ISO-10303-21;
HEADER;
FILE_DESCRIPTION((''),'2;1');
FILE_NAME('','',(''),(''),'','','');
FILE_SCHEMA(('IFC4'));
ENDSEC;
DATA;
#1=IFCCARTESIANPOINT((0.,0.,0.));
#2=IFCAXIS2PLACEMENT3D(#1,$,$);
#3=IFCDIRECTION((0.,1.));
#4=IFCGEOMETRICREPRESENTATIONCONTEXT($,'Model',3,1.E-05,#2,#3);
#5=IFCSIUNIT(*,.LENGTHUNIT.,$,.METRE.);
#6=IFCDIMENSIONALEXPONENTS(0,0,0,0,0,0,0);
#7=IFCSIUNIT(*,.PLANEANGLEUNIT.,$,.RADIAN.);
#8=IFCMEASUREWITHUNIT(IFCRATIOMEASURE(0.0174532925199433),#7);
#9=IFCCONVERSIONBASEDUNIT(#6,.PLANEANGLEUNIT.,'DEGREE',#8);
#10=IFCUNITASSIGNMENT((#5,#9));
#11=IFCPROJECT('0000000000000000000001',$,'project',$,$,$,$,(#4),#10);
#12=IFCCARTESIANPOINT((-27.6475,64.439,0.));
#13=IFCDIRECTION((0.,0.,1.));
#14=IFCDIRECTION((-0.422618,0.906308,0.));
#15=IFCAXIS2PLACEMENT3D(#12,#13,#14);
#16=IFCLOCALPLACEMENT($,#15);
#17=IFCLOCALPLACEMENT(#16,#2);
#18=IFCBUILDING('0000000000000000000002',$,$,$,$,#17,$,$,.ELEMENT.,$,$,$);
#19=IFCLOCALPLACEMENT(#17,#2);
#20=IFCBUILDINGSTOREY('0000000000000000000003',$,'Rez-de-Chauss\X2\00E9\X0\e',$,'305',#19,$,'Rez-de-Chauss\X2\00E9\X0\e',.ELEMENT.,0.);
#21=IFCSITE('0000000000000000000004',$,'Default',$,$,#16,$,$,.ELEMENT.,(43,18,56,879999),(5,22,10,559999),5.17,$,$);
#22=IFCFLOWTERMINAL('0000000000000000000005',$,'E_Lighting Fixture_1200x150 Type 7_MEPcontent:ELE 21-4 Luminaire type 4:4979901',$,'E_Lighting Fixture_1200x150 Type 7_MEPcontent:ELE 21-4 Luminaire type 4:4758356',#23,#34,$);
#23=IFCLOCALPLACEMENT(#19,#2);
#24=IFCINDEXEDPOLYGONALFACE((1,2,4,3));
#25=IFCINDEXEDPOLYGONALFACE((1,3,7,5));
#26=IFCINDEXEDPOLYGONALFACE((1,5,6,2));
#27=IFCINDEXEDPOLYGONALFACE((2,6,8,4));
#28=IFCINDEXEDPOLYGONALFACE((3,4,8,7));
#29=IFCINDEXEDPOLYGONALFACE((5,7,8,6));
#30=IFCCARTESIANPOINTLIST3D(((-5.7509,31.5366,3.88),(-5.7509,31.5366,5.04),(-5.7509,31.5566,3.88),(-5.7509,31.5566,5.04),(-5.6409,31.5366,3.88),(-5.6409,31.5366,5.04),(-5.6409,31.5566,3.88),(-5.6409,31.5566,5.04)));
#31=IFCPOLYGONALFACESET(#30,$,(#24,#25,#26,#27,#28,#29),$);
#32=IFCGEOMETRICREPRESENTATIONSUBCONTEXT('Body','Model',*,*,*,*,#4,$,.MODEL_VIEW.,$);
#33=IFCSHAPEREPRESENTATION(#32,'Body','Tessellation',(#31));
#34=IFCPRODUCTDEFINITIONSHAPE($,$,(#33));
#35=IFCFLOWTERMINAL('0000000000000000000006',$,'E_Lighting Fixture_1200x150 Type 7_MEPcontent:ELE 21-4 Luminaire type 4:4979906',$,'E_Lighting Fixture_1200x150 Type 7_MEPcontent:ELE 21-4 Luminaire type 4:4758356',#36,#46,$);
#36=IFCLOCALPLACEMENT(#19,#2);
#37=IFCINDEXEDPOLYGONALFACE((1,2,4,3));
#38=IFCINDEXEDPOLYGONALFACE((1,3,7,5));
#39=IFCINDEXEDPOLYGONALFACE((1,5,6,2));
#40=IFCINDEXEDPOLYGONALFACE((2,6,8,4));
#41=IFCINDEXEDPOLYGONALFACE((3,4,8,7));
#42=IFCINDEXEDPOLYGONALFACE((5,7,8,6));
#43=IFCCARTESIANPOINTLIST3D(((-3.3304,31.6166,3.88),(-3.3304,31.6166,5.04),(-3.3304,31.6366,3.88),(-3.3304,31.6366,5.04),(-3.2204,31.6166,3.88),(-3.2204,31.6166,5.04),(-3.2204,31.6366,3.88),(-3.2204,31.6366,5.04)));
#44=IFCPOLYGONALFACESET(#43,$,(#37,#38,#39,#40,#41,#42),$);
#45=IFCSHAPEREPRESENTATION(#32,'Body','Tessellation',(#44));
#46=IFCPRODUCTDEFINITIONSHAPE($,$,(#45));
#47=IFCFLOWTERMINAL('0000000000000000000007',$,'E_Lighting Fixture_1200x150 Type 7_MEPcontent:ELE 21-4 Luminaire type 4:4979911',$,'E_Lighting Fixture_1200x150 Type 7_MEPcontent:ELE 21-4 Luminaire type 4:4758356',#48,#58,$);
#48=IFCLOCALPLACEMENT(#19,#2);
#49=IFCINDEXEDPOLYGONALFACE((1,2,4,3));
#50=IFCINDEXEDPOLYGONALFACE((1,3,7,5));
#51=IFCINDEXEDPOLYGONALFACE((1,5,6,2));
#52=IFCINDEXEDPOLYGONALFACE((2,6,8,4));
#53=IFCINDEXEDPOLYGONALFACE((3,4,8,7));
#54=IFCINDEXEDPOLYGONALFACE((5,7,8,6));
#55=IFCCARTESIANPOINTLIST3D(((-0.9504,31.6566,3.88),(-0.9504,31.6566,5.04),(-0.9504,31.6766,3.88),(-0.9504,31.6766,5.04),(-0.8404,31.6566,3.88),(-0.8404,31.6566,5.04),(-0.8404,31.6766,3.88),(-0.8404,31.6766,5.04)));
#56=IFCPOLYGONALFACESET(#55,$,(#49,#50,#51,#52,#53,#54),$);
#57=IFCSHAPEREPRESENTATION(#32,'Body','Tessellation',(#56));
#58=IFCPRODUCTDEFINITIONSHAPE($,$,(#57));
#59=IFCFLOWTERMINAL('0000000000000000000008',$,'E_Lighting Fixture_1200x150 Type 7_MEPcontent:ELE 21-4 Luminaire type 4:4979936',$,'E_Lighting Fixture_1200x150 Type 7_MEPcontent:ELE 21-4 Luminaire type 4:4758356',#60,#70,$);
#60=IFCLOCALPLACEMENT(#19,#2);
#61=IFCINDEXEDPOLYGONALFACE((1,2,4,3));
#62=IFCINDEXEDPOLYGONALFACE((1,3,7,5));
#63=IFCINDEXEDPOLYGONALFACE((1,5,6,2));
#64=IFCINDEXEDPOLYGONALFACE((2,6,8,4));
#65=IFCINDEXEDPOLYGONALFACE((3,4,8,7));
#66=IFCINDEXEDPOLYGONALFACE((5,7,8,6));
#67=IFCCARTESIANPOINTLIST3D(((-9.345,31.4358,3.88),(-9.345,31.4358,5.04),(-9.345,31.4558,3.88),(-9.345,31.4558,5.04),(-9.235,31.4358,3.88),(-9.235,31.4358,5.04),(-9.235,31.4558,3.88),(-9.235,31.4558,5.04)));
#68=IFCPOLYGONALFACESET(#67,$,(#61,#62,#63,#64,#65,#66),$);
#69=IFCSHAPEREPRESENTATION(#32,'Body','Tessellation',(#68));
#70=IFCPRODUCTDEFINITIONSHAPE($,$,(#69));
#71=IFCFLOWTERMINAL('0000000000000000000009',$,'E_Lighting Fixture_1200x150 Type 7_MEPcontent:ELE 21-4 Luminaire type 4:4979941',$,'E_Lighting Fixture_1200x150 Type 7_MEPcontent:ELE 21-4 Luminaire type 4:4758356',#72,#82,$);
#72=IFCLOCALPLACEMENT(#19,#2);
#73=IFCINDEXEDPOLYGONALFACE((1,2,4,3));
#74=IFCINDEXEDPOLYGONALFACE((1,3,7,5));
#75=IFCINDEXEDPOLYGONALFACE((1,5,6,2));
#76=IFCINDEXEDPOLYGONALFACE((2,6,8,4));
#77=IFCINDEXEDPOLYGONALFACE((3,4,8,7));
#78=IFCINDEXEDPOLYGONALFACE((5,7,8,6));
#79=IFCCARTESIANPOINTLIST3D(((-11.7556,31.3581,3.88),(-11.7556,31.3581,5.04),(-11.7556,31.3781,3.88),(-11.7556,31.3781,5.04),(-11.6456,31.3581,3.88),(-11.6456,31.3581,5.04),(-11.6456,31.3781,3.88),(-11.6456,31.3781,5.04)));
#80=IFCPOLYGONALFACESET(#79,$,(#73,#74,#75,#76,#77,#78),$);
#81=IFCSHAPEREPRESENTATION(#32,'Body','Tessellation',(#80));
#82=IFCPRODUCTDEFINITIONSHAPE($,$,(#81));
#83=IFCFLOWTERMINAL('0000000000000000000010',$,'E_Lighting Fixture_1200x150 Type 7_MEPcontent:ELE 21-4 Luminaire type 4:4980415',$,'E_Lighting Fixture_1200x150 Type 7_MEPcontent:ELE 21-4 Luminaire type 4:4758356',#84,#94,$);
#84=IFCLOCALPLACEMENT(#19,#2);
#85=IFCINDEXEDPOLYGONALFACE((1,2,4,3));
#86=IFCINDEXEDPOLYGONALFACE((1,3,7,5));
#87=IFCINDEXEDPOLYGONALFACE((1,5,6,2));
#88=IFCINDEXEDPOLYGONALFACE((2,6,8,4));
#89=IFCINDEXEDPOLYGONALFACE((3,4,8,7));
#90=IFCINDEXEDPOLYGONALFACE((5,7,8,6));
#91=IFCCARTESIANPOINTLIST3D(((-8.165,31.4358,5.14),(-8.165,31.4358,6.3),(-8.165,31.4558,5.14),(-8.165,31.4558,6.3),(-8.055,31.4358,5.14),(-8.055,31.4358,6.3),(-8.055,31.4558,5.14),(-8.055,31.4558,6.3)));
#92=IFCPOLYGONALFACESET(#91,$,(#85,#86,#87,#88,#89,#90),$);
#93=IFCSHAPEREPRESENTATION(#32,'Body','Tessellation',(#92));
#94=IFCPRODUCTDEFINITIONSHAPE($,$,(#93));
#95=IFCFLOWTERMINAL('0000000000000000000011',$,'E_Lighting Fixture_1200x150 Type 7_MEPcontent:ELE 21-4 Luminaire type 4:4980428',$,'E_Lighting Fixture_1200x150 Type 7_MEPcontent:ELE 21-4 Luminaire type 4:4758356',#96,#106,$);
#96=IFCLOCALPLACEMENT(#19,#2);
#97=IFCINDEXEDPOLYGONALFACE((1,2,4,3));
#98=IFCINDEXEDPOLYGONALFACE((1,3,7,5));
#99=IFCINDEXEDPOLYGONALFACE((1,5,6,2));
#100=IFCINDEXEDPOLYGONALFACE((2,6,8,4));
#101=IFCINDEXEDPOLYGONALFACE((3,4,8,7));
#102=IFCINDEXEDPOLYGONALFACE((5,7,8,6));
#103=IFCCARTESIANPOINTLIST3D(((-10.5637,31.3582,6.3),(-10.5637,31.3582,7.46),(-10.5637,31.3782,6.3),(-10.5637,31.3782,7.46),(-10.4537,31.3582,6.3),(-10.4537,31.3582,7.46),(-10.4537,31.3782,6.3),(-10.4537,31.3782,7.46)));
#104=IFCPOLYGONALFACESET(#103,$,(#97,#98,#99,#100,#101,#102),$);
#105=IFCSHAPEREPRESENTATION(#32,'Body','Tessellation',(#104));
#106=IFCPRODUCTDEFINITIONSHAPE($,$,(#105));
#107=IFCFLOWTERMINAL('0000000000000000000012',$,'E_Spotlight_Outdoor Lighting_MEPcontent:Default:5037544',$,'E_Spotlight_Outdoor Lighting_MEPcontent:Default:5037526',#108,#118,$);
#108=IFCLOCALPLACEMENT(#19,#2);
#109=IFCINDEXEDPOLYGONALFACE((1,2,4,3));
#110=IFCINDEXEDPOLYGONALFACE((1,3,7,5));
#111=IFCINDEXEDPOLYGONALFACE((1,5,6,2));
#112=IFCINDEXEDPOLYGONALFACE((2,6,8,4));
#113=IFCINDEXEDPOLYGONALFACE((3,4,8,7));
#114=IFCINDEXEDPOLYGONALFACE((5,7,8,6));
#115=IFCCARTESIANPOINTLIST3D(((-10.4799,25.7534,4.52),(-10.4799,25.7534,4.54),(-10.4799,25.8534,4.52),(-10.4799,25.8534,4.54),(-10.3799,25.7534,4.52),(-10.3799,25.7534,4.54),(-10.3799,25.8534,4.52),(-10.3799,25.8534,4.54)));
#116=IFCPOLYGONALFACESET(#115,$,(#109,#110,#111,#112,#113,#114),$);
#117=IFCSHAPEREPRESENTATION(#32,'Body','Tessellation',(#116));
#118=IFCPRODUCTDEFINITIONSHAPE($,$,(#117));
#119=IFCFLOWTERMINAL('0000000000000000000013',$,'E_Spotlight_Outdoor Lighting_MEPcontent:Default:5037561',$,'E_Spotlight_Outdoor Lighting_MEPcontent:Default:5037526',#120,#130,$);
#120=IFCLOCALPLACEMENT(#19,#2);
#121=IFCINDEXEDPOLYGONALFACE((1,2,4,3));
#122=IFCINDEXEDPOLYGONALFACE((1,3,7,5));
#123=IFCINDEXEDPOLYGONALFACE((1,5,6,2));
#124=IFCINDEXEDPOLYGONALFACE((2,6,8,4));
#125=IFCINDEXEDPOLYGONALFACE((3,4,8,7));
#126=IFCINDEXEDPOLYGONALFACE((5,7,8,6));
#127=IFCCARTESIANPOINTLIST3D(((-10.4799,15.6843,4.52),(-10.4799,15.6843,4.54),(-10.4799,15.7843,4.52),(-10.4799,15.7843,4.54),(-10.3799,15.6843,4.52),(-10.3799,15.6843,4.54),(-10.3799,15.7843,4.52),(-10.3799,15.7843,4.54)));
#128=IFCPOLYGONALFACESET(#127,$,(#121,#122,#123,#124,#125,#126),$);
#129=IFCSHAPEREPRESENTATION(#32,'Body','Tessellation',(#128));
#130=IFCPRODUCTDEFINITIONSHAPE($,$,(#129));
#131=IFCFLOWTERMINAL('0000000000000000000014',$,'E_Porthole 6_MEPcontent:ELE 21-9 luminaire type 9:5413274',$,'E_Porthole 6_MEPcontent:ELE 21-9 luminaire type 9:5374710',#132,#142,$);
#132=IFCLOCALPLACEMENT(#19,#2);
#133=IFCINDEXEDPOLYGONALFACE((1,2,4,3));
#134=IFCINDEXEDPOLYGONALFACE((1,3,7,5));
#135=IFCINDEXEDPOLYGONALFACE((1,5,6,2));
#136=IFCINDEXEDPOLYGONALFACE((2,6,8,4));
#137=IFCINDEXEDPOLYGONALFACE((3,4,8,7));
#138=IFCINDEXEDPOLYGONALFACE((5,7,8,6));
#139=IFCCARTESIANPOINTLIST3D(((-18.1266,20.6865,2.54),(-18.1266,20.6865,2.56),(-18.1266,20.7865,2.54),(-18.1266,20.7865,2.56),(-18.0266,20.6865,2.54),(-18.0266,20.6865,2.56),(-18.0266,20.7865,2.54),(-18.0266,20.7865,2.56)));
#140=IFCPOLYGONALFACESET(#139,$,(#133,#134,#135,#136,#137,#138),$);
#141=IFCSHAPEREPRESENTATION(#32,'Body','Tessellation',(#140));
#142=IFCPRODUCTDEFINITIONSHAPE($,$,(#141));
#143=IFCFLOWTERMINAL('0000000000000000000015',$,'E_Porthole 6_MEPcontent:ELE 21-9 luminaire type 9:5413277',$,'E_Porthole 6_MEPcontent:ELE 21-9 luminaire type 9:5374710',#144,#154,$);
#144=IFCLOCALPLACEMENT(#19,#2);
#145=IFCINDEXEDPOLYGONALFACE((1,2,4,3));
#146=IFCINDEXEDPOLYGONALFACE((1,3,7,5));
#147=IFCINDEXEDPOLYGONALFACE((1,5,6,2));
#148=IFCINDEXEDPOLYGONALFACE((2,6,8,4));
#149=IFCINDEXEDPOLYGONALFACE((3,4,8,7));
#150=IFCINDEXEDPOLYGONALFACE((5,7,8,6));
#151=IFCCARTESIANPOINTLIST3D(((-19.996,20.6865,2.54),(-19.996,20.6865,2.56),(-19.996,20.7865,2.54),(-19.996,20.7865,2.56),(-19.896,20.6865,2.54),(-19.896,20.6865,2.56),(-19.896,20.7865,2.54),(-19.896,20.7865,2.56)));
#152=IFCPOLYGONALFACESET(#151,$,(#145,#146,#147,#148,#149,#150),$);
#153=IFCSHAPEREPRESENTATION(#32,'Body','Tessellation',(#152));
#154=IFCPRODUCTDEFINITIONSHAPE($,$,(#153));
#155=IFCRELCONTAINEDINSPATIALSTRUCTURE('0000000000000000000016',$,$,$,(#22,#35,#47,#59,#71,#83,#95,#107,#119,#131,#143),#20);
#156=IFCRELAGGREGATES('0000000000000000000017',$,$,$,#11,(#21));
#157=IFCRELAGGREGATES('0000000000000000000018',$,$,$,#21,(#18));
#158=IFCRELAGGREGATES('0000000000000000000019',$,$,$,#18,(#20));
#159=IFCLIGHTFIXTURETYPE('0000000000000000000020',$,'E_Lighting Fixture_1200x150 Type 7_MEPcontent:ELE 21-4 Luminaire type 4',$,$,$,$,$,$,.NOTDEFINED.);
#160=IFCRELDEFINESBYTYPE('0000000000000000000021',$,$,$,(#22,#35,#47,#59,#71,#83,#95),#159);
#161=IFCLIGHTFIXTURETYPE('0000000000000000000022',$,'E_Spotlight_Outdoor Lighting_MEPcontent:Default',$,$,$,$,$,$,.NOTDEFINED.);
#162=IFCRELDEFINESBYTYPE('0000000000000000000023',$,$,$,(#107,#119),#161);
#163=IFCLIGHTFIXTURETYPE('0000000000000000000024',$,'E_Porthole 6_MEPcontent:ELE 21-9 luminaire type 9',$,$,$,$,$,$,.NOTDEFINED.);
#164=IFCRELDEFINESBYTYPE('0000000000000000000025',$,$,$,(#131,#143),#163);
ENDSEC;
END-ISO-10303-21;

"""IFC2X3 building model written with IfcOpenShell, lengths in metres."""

from ifc_helpers import new_model, entity, si_unit, converted_unit, direction, frame, frame_2d, origin, origin_2d_with_axis, place, context, subcontext, project, spatial, rectangle, extrude, source, transform, mapped, type_object, type_shapes, element, save


model = new_model("IFC2X3")

# Units and contexts
model_context = context("Model", 3, precision=1e-05, world=origin(), true_north=direction((0.0, 1.0)))
body_context = subcontext(model_context, "Body", "Model", "MODEL_VIEW")
ifc_project = project(units=[si_unit("LENGTHUNIT", "METRE"), converted_unit("PLANEANGLEUNIT", "DEGREE", entity("IfcRatioMeasure", 0.0174532925199433), si_unit("PLANEANGLEUNIT", "RADIAN"), dimensions=[0, 0, 0, 0, 0, 0, 0])], contexts=[model_context])

# Site, building, storey
site_placement = place(None, frame((-27.6475, 64.439, 0.0), z_axis=(0.0, 0.0, 1.0), x_axis=(-0.422618, 0.906308, 0.0)))
site = spatial("IfcSite", under=ifc_project, at=site_placement, Name="Default", CompositionType="ELEMENT", RefLatitude=(43, 18, 56, 879999), RefLongitude=(5, 22, 10, 559999), RefElevation=5.17)
building_placement = place(site_placement, origin())
building = spatial("IfcBuilding", under=site, at=building_placement, CompositionType="ELEMENT")
storey_placement = place(building_placement, origin())
storey = spatial("IfcBuildingStorey", under=building, at=storey_placement, Name="Rez-de-Chaussée", ObjectType="305", LongName="Rez-de-Chaussée", CompositionType="ELEMENT", Elevation=0.0)

# Flow terminals
light_fixture_type_1 = type_object("IfcLightFixtureType", Name="E_Lighting Fixture_1200x150 Type 7_MEPcontent:ELE 21-4 Luminaire type 4", PredefinedType="NOTDEFINED")
shared_shape_1 = source(origin(), body_context, "Body", "SweptSolid", [
    extrude(rectangle(XDim=0.02, YDim=0.11, at=frame_2d((0.0, 0.0), x_axis=(1.0, 0.0))), frame((0.01, 0.0, -0.58), z_axis=(0.0, 0.0, 1.0), x_axis=(-1.0, 0.0, 0.0)), (0.0, 0.0, 1.0), 1.16),
])
type_shapes(light_fixture_type_1, [shared_shape_1])
for number, where, z_axis, x_axis, name in (
    (1, (-5.6959, 31.5566, 4.46), (0.0, 0.0, 1.0), (0.0, -1.0, 0.0), "E_Lighting Fixture_1200x150 Type 7_MEPcontent:ELE 21-4 Luminaire type 4:4979901"),
    (2, (-3.2754, 31.6366, 4.46), (0.0, 0.0, 1.0), (0.0, -1.0, 0.0), "E_Lighting Fixture_1200x150 Type 7_MEPcontent:ELE 21-4 Luminaire type 4:4979906"),
    (3, (-0.8954, 31.6766, 4.46), (0.0, 0.0, 1.0), (0.0, -1.0, 0.0), "E_Lighting Fixture_1200x150 Type 7_MEPcontent:ELE 21-4 Luminaire type 4:4979911"),
    (4, (-9.29, 31.4558, 4.46), (0.0, 0.0, 1.0), (0.0, -1.0, 0.0), "E_Lighting Fixture_1200x150 Type 7_MEPcontent:ELE 21-4 Luminaire type 4:4979936"),
    (5, (-11.7006, 31.3781, 4.46), (0.0, 0.0, 1.0), (0.0, -1.0, 0.0), "E_Lighting Fixture_1200x150 Type 7_MEPcontent:ELE 21-4 Luminaire type 4:4979941"),
    (6, (-8.11, 31.4558, 5.72), (0.0, 0.0, 1.0), (0.0, -1.0, 0.0), "E_Lighting Fixture_1200x150 Type 7_MEPcontent:ELE 21-4 Luminaire type 4:4980415"),
    (7, (-10.5087, 31.3782, 6.88), (0.0, 0.0, 1.0), (0.0, -1.0, 0.0), "E_Lighting Fixture_1200x150 Type 7_MEPcontent:ELE 21-4 Luminaire type 4:4980428"),
):
    element("IfcFlowTerminal", number, at=place(storey_placement, frame(where, z_axis=z_axis, x_axis=x_axis)), inside=storey, type_object=light_fixture_type_1, Name=name, ObjectType="E_Lighting Fixture_1200x150 Type 7_MEPcontent:ELE 21-4 Luminaire type 4:4758356", context=body_context, shape_type="MappedRepresentation", body=[
        mapped(shared_shape_1, transform((0.0, 0.0, 0.0), scale=1.0)),
    ])
light_fixture_type_2 = type_object("IfcLightFixtureType", Name="E_Spotlight_Outdoor Lighting_MEPcontent:Default", PredefinedType="NOTDEFINED")
shared_shape_2 = source(origin(), body_context, "Body", "SweptSolid", [
    extrude(rectangle(XDim=0.1, YDim=0.1, at=origin_2d_with_axis()), frame((0.0, 0.0, 0.0), z_axis=(0.0, 0.0, 1.0), x_axis=(0.0, -1.0, 0.0)), (0.0, 0.0, 1.0), 0.02),
])
type_shapes(light_fixture_type_2, [shared_shape_2])
for number, where, z_axis, x_axis, name in (
    (8, (-10.4299, 25.8034, 4.52), (0.0, 0.0, 1.0), (0.0, -1.0, 0.0), "E_Spotlight_Outdoor Lighting_MEPcontent:Default:5037544"),
    (9, (-10.4299, 15.7343, 4.52), (0.0, 0.0, 1.0), (0.0, -1.0, 0.0), "E_Spotlight_Outdoor Lighting_MEPcontent:Default:5037561"),
):
    element("IfcFlowTerminal", number, at=place(storey_placement, frame(where, z_axis=z_axis, x_axis=x_axis)), inside=storey, type_object=light_fixture_type_2, Name=name, ObjectType="E_Spotlight_Outdoor Lighting_MEPcontent:Default:5037526", context=body_context, shape_type="MappedRepresentation", body=[
        mapped(shared_shape_2, transform((0.0, 0.0, 0.0), scale=1.0)),
    ])
light_fixture_type_3 = type_object("IfcLightFixtureType", Name="E_Porthole 6_MEPcontent:ELE 21-9 luminaire type 9", PredefinedType="NOTDEFINED")
shared_shape_3 = source(origin(), body_context, "Body", "SweptSolid", [
    extrude(rectangle(XDim=0.1, YDim=0.1, at=origin_2d_with_axis()), frame((0.0, 0.0, 0.0), z_axis=(0.0, 0.0, 1.0), x_axis=(0.0, -1.0, 0.0)), (0.0, 0.0, 1.0), 0.02),
])
type_shapes(light_fixture_type_3, [shared_shape_3])
for number, where, z_axis, x_axis, name in (
    (10, (-18.0766, 20.7365, 2.54), (0.0, 0.0, 1.0), (0.0, -1.0, 0.0), "E_Porthole 6_MEPcontent:ELE 21-9 luminaire type 9:5413274"),
    (11, (-19.946, 20.7365, 2.54), (0.0, 0.0, 1.0), (0.0, -1.0, 0.0), "E_Porthole 6_MEPcontent:ELE 21-9 luminaire type 9:5413277"),
):
    element("IfcFlowTerminal", number, at=place(storey_placement, frame(where, z_axis=z_axis, x_axis=x_axis)), inside=storey, type_object=light_fixture_type_3, Name=name, ObjectType="E_Porthole 6_MEPcontent:ELE 21-9 luminaire type 9:5374710", context=body_context, shape_type="MappedRepresentation", body=[
        mapped(shared_shape_3, transform((0.0, 0.0, 0.0), scale=1.0)),
    ])

save(model, "model.ifc")
